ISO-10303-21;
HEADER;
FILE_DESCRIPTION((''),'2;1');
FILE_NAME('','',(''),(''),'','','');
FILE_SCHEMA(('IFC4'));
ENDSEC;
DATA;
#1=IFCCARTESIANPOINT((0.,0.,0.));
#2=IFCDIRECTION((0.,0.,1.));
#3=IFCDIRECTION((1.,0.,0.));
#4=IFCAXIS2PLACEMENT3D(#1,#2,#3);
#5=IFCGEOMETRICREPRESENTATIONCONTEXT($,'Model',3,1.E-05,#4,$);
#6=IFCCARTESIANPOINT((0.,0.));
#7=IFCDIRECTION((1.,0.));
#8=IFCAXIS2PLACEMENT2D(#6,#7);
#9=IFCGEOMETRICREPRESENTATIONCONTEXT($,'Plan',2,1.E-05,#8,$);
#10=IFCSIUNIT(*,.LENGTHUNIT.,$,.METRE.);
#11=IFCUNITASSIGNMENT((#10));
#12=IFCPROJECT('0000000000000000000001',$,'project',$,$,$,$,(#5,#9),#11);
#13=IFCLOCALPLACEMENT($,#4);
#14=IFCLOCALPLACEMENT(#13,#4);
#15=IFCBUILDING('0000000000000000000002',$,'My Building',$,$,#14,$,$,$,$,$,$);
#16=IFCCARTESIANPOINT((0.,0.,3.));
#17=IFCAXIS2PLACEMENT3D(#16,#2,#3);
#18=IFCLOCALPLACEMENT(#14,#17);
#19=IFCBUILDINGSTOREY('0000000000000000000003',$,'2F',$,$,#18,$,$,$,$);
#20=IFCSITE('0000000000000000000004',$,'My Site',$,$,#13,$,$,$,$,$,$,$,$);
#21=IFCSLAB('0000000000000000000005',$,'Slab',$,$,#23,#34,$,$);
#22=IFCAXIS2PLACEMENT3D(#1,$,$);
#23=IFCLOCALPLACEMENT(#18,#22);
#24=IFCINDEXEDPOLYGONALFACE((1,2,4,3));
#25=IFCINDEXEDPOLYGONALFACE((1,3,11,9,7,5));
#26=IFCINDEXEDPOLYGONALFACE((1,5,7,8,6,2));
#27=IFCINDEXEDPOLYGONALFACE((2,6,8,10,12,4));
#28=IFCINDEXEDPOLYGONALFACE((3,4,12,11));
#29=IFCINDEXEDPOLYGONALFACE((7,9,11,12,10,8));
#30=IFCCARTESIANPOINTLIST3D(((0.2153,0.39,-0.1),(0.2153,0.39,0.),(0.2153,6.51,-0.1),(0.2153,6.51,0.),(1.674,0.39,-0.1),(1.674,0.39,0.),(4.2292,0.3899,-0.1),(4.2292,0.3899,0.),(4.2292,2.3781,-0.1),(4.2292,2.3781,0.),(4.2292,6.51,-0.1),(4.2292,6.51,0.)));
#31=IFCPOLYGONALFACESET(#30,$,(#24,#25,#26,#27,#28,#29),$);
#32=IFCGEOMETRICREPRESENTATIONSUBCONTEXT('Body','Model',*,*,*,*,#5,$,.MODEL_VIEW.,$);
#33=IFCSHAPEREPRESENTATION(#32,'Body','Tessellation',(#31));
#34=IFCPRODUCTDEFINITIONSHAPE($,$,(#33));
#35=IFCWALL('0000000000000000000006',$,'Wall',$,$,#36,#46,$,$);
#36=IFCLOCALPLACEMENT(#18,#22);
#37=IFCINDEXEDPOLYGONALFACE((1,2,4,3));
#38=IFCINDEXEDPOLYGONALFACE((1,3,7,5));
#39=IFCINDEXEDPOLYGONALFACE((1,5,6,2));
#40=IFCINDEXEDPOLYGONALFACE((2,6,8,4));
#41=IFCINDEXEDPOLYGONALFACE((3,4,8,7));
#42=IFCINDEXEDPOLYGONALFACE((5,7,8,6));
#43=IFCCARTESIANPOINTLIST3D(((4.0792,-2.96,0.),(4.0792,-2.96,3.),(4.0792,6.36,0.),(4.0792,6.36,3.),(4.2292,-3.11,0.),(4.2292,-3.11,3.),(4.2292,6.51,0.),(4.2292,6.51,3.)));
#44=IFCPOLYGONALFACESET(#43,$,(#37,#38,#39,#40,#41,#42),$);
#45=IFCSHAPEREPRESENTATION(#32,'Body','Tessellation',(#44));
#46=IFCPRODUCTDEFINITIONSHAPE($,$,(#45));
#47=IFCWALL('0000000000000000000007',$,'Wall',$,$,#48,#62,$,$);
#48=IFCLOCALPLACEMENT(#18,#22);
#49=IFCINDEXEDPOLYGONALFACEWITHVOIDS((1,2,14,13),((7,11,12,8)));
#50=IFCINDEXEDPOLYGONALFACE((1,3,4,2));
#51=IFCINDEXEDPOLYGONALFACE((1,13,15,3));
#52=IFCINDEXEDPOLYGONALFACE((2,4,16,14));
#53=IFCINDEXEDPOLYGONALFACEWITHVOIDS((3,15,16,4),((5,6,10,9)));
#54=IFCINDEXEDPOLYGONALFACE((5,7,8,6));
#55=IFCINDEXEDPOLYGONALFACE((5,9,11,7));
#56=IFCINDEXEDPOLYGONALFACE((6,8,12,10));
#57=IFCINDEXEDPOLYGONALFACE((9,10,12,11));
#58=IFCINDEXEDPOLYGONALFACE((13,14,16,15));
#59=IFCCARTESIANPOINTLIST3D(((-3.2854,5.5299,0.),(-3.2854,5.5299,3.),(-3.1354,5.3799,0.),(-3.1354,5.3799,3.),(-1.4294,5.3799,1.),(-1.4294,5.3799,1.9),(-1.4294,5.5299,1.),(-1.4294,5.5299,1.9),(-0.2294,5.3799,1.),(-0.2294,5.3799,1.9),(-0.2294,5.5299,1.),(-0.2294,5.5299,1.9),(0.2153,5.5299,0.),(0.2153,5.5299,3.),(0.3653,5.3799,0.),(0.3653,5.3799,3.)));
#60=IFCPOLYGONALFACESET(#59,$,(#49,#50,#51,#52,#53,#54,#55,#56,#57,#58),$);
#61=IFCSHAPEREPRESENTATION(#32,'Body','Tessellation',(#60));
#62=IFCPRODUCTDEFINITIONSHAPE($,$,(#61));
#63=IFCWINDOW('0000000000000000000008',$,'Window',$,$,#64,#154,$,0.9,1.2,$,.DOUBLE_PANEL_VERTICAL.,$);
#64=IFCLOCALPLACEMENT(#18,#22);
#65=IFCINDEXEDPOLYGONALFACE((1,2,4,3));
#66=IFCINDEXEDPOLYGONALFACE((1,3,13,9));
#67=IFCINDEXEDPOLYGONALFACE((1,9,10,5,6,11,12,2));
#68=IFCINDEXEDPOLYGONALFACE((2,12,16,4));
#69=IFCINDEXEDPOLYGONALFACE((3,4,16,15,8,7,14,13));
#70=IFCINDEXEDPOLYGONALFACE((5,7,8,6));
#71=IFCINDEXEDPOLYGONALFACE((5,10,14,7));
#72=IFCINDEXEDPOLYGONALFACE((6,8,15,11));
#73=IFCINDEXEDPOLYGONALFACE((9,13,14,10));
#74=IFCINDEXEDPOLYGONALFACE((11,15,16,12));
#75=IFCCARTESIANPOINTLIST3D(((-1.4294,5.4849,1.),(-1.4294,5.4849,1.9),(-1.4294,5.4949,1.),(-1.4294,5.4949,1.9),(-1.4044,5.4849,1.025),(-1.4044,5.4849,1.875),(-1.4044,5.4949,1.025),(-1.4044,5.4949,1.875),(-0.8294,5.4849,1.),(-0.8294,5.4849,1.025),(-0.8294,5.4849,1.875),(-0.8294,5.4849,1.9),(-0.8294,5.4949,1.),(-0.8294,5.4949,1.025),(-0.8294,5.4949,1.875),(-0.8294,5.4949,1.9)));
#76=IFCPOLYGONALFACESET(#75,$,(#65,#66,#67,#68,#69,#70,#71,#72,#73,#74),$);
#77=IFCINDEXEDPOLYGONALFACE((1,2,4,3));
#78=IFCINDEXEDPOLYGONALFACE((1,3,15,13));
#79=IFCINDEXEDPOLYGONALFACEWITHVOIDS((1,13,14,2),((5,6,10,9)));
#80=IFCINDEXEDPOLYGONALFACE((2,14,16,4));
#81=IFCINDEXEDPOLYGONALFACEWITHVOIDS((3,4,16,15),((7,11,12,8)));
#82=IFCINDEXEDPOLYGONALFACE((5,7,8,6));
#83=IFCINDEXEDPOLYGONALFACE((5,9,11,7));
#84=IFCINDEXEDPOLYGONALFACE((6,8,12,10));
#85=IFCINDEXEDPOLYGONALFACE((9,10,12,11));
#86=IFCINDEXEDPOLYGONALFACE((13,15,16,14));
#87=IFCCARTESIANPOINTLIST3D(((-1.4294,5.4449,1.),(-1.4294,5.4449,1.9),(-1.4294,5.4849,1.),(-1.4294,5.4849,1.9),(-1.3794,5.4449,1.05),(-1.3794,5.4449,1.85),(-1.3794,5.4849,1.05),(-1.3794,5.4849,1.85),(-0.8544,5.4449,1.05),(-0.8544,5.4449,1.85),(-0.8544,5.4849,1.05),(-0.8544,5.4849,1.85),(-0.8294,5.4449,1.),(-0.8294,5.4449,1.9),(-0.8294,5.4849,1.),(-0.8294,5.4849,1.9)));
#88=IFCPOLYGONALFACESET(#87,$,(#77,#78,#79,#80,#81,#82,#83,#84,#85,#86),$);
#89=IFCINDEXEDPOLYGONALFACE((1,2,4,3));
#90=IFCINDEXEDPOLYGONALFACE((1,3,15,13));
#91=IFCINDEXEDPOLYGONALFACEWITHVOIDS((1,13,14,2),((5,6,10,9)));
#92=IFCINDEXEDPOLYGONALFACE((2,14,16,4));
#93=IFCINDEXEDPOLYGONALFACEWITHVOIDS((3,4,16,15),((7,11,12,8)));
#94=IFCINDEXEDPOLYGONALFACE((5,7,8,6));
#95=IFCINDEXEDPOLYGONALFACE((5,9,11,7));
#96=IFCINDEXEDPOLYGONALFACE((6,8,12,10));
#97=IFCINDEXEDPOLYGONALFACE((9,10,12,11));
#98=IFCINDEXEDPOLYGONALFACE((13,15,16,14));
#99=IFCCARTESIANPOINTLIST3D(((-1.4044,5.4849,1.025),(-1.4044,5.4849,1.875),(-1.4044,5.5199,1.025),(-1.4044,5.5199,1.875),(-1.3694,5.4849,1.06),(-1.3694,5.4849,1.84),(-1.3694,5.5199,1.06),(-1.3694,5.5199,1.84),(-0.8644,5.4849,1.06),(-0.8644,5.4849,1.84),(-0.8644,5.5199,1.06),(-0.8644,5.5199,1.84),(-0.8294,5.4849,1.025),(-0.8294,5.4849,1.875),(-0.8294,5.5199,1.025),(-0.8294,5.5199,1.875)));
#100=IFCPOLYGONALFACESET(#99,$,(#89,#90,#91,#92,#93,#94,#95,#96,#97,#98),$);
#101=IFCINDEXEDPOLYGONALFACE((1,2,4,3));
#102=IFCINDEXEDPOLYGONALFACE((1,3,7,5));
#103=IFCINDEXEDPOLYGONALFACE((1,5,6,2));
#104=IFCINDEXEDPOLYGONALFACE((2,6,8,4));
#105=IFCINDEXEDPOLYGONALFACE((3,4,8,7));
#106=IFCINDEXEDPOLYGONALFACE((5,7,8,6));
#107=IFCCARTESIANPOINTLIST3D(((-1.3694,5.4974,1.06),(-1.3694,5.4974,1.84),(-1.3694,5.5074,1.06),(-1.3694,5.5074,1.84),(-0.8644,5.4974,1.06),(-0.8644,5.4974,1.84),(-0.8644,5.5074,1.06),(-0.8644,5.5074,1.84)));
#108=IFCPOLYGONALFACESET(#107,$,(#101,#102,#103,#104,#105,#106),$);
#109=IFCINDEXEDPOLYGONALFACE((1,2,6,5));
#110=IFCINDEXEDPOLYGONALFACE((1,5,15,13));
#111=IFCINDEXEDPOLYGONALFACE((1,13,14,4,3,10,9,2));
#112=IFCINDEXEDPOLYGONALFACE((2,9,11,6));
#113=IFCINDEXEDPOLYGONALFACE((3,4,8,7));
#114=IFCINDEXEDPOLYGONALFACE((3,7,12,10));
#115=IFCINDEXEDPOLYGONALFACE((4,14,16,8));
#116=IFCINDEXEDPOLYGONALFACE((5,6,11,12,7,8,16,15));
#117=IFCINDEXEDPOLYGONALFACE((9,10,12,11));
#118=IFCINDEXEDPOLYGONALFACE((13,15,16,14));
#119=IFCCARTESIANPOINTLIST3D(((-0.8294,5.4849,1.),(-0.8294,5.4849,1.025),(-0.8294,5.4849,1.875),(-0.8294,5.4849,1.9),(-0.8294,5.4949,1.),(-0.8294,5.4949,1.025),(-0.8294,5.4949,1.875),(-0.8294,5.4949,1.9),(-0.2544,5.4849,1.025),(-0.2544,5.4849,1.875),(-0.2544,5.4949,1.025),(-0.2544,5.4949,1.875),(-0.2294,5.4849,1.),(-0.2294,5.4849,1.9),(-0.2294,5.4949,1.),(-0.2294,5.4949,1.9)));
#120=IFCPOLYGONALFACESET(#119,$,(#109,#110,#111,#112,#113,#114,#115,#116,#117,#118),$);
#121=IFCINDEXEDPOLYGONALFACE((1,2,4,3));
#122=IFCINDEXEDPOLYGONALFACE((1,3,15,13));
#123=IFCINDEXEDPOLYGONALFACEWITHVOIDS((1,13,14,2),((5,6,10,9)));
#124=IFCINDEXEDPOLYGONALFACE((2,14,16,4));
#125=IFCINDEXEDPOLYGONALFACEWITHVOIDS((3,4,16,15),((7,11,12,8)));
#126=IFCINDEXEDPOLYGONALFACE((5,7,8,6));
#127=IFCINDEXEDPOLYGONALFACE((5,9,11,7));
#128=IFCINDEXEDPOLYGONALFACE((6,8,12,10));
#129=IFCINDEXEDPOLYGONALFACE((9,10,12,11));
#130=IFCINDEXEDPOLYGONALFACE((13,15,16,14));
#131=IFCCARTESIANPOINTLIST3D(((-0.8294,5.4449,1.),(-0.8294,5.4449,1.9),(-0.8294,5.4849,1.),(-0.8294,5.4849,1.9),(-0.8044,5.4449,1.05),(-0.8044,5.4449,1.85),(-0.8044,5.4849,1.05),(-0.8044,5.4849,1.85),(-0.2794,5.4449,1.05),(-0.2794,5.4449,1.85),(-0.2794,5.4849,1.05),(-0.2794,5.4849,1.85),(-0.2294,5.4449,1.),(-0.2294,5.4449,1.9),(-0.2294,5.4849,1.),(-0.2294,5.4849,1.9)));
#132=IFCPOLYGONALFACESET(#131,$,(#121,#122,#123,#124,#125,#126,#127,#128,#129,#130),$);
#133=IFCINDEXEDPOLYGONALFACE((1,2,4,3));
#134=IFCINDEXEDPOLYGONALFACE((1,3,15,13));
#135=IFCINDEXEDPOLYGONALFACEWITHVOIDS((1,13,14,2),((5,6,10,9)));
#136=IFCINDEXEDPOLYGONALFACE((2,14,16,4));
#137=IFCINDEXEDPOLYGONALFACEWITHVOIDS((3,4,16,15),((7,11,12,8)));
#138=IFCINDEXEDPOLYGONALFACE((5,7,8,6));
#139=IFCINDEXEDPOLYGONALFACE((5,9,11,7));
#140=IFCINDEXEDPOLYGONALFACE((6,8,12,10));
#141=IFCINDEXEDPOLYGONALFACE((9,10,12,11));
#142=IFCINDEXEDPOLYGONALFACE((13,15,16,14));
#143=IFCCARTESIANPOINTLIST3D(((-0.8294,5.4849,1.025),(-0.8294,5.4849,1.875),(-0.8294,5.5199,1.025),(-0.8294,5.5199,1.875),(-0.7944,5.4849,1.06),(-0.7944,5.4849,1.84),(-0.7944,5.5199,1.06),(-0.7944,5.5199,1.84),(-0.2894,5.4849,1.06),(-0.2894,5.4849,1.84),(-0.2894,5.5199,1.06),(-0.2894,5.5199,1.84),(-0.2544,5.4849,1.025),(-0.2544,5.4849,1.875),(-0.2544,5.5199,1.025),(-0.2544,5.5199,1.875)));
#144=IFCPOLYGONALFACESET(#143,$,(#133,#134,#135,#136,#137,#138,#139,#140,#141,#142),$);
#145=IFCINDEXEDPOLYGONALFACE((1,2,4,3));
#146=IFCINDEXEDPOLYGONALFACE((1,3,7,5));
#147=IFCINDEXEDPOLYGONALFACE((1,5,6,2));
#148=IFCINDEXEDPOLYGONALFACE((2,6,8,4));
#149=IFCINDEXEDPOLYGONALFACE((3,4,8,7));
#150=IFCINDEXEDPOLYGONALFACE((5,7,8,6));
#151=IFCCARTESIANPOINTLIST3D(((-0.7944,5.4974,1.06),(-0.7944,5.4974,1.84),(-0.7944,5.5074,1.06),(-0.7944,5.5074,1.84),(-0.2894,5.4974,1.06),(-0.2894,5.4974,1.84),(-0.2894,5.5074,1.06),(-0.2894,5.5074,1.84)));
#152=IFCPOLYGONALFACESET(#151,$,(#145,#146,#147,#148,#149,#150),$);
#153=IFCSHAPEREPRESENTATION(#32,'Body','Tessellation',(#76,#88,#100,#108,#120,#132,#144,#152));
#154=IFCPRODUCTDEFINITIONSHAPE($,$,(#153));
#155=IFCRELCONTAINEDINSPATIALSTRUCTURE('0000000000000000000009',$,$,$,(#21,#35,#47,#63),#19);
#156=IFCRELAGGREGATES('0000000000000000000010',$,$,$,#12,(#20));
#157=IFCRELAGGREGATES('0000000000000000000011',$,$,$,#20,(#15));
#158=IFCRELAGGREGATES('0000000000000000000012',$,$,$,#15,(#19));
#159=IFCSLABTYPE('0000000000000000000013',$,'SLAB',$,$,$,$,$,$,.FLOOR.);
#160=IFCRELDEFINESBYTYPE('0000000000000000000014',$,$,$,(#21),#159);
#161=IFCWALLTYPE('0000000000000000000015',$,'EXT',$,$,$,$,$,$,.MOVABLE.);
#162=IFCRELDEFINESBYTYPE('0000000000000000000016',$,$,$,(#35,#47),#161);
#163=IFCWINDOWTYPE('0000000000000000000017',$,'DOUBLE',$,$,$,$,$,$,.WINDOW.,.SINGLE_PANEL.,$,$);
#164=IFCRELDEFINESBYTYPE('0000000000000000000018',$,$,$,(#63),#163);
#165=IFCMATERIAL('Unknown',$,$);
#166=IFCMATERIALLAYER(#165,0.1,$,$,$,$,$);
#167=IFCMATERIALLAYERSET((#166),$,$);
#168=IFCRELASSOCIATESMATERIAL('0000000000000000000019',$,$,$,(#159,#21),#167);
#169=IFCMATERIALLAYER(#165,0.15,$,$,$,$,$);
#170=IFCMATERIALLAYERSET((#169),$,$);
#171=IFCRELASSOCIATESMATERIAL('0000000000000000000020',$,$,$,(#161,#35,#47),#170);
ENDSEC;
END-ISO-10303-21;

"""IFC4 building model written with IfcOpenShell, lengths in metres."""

from ifc_helpers import new_model, entity, si_unit, frame, origin_with_axes, origin_2d_with_axis, place, context, subcontext, project, spatial, line, indexed_curve, outline, extrude, shape, source, transform, mapped, material, layer, layer_set, layer_usage, type_object, type_shapes, element, fill, save


model = new_model("IFC4")

# Units and contexts
model_context = context("Model", 3, precision=1e-05, world=origin_with_axes())
plan_context = context("Plan", 2, precision=1e-05, world=origin_2d_with_axis())
body_context_1 = subcontext(model_context, "Body", "Model", "MODEL_VIEW")
body_context_2 = subcontext(plan_context, "Body", "Plan", "PLAN_VIEW")
ifc_project = project(units=[si_unit("LENGTHUNIT", "METRE")], contexts=[model_context, plan_context])

# Site, building, storey
site_placement = place(None, origin_with_axes())
site = spatial("IfcSite", under=ifc_project, at=site_placement, Name="My Site")
building_placement = place(site_placement, origin_with_axes())
building = spatial("IfcBuilding", under=site, at=building_placement, Name="My Building")
storey_placement = place(building_placement, frame((0.0, 0.0, 3.0), z_axis=(0.0, 0.0, 1.0), x_axis=(1.0, 0.0, 0.0)))
storey = spatial("IfcBuildingStorey", under=building, at=storey_placement, Name="2F")

# Slab
ifc_material = material(Name="Unknown")
ifc_layer_1 = layer(ifc_material, 0.1)
ifc_layer_set_1 = layer_set([ifc_layer_1])
ifc_layer_usage_1 = layer_usage(ifc_layer_set_1, "AXIS3", "POSITIVE", -0.1)
slab_type = type_object("IfcSlabType", Name="SLAB", PredefinedType="FLOOR", material=ifc_layer_set_1)
slab_placement = place(storey_placement, frame((1.6739, 2.3781, 0.0), z_axis=(0.0, 0.0, 1.0), x_axis=(1.0, 0.0, 0.0)))
element("IfcSlab", 1, at=slab_placement, inside=storey, type_object=slab_type, material=ifc_layer_usage_1, Name="Slab", context=body_context_1, shape_type="SweptSolid", body=[
    extrude(outline(indexed_curve([(0.0, -1.9882), (-1.4586, -1.9882), (-1.4586, 4.1319), (2.5552, 4.1319), (2.5552, 0.0), (2.5553, -1.9883), (0.0, -1.9882)])), frame((0.0, 0.0, -0.1), z_axis=(0.0, 0.0, 1.0), x_axis=(1.0, 0.0, 0.0)), (0.0, 0.0, 1.0), 0.1),
])

# Wall
ifc_layer_2 = layer(ifc_material, 0.15)
ifc_layer_set_2 = layer_set([ifc_layer_2])
ifc_layer_usage_2 = layer_usage(ifc_layer_set_2, "AXIS2", "POSITIVE", -0.15)
wall_type_1 = type_object("IfcWallType", Name="EXT", PredefinedType="MOVABLE", material=ifc_layer_set_2)
wall_1_placement = place(storey_placement, frame((4.2292, 6.51, 0.0), z_axis=(0.0, 0.0, 1.0), x_axis=(0.0, -1.0, 0.0)))
element("IfcWall", 2, at=wall_1_placement, inside=storey, type_object=wall_type_1, material=ifc_layer_usage_2, Name="Wall", context=body_context_1, shape_type="SweptSolid", body=[
    extrude(outline(indexed_curve([(0.15, -0.15), (0.0, 0.0), (9.62, 0.0), (9.47, -0.15)], segments=[line(1, 2, 3, 4, 1)])), origin_with_axes(), (0.0, 0.0, 1.0), 3.0),
])

# Wall, opening, window
ifc_layer_usage_3 = layer_usage(ifc_layer_set_2, "AXIS2", "POSITIVE", -0.15)
wall_2_placement = place(storey_placement, frame((-3.2854, 5.5299, 0.0), z_axis=(0.0, 0.0, 1.0), x_axis=(1.0, 0.0, 0.0)))
wall_2 = element("IfcWall", 3, at=wall_2_placement, inside=storey, type_object=wall_type_1, material=ifc_layer_usage_3, Name="Wall", context=body_context_1, shape_type="SweptSolid", body=[
    extrude(outline(indexed_curve([(0.15, -0.15), (0.0, 0.0), (3.5007, 0.0), (3.6507, -0.15)], segments=[line(1, 2, 3, 4, 1)])), origin_with_axes(), (0.0, 0.0, 1.0), 3.0),
])
placement_1 = place(storey_placement, frame((-1.4294, 5.3949, 1.0), z_axis=(0.0, 0.0, 1.0), x_axis=(1.0, 0.0, 0.0)))
opening_1 = element("IfcOpeningElement", 4, at=placement_1, cuts=wall_2, PredefinedType="OPENING", context=body_context_1, shape_type="SweptSolid", body=[
    extrude(outline(indexed_curve([(0.0, 0.0), (1.2, 0.0), (1.2, 0.9), (0.0, 0.9)], segments=[line(1, 2, 3, 4, 1)])), frame((0.0, -0.6, 0.0), z_axis=(0.0, -1.0, 0.0), x_axis=(1.0, 0.0, 0.0)), (0.0, 0.0, -1.0), 1.2),
])
window_type_1 = type_object("IfcWindowType", Name="DOUBLE", PartitioningType="SINGLE_PANEL", PredefinedType="WINDOW")
shared_shape_1 = source(origin_with_axes(), body_context_1, "Body", "SweptSolid", [
    extrude(outline(indexed_curve([(0.6, 0.0), (0.0, 0.0), (0.0, 0.9), (0.6, 0.9), (0.6, 0.875), (0.025, 0.875), (0.025, 0.025), (0.6, 0.025)], segments=[line(1, 2, 3, 4, 5, 6, 7, 8, 1)])), frame((0.0, 0.09, 0.0), z_axis=(0.0, -1.0, 0.0), x_axis=(1.0, 0.0, 0.0)), (0.0, 0.0, -1.0), 0.01),
    extrude(outline(indexed_curve([(0.0, 0.0), (0.6, 0.0), (0.6, 0.9), (0.0, 0.9)], segments=[line(1, 2, 3, 4, 1)]), holes=[indexed_curve([(0.05, 0.05), (0.575, 0.05), (0.575, 0.85), (0.05, 0.85)], segments=[line(1, 2, 3, 4, 1)])]), frame((0.0, 0.05, 0.0), z_axis=(0.0, -1.0, 0.0), x_axis=(1.0, 0.0, 0.0)), (0.0, 0.0, -1.0), 0.04),
    extrude(outline(indexed_curve([(0.0, 0.0), (0.575, 0.0), (0.575, 0.85), (0.0, 0.85)], segments=[line(1, 2, 3, 4, 1)]), holes=[indexed_curve([(0.035, 0.035), (0.54, 0.035), (0.54, 0.815), (0.035, 0.815)], segments=[line(1, 2, 3, 4, 1)])]), frame((0.025, 0.09, 0.025), z_axis=(0.0, -1.0, 0.0), x_axis=(1.0, 0.0, 0.0)), (0.0, 0.0, -1.0), 0.035),
    extrude(outline(indexed_curve([(0.035, 0.035), (0.54, 0.035), (0.54, 0.815), (0.035, 0.815)], segments=[line(1, 2, 3, 4, 1)])), frame((0.025, 0.1025, 0.025), z_axis=(0.0, -1.0, 0.0), x_axis=(1.0, 0.0, 0.0)), (0.0, 0.0, -1.0), 0.01),
    extrude(outline(indexed_curve([(0.0, 0.9), (0.6, 0.9), (0.6, 0.0), (0.0, 0.0), (0.0, 0.025), (0.575, 0.025), (0.575, 0.875), (0.0, 0.875)], segments=[line(1, 2, 3, 4, 5, 6, 7, 8, 1)])), frame((0.6, 0.09, 0.0), z_axis=(0.0, -1.0, 0.0), x_axis=(1.0, 0.0, 0.0)), (0.0, 0.0, -1.0), 0.01),
    extrude(outline(indexed_curve([(0.0, 0.0), (0.6, 0.0), (0.6, 0.9), (0.0, 0.9)], segments=[line(1, 2, 3, 4, 1)]), holes=[indexed_curve([(0.025, 0.05), (0.55, 0.05), (0.55, 0.85), (0.025, 0.85)], segments=[line(1, 2, 3, 4, 1)])]), frame((0.6, 0.05, 0.0), z_axis=(0.0, -1.0, 0.0), x_axis=(1.0, 0.0, 0.0)), (0.0, 0.0, -1.0), 0.04),
    extrude(outline(indexed_curve([(0.0, 0.0), (0.575, 0.0), (0.575, 0.85), (0.0, 0.85)], segments=[line(1, 2, 3, 4, 1)]), holes=[indexed_curve([(0.035, 0.035), (0.54, 0.035), (0.54, 0.815), (0.035, 0.815)], segments=[line(1, 2, 3, 4, 1)])]), frame((0.6, 0.09, 0.025), z_axis=(0.0, -1.0, 0.0), x_axis=(1.0, 0.0, 0.0)), (0.0, 0.0, -1.0), 0.035),
    extrude(outline(indexed_curve([(0.035, 0.815), (0.54, 0.815), (0.54, 0.035), (0.035, 0.035), (0.035, 0.815)])), frame((0.6, 0.1025, 0.025), z_axis=(0.0, -1.0, 0.0), x_axis=(1.0, 0.0, 0.0)), (0.0, 0.0, -1.0), 0.01),
])
shared_shape_2 = source(origin_with_axes(), body_context_2, "Body", "Curve2D", [
    entity("IfcIndexedPolyCurve", entity("IfcCartesianPointList2D", [[0.05, 0.05], [0.575, 0.05]])),
    entity("IfcIndexedPolyCurve", entity("IfcCartesianPointList2D", [[0.0, 0.1], [0.025, 0.1], [0.025, 0.09], [0.05, 0.09], [0.05, 0.05], [0.0, 0.05]]), [entity("IfcLineIndex", [1, 2, 3, 4, 5, 6, 1])]),
    entity("IfcIndexedPolyCurve", entity("IfcCartesianPointList2D", [[0.6, 0.1], [0.6, 0.1], [0.6, 0.09], [0.575, 0.09], [0.575, 0.05], [0.6, 0.05]])),
    entity("IfcIndexedPolyCurve", entity("IfcCartesianPointList2D", [[0.025, 0.09], [0.06, 0.09], [0.06, 0.125], [0.025, 0.125]]), [entity("IfcLineIndex", [1, 2, 3, 4, 1])]),
    entity("IfcIndexedPolyCurve", entity("IfcCartesianPointList2D", [[0.6, 0.09], [0.565, 0.09], [0.565, 0.125], [0.6, 0.125]]), [entity("IfcLineIndex", [1, 2, 3, 4, 1])]),
    entity("IfcIndexedPolyCurve", entity("IfcCartesianPointList2D", [[0.06, 0.09], [0.565, 0.09]])),
    entity("IfcIndexedPolyCurve", entity("IfcCartesianPointList2D", [[0.06, 0.125], [0.565, 0.125]])),
    entity("IfcIndexedPolyCurve", entity("IfcCartesianPointList2D", [[0.06, 0.1075], [0.565, 0.1075]])),
    entity("IfcIndexedPolyCurve", entity("IfcCartesianPointList2D", [[0.625, 0.05], [1.15, 0.05]])),
    entity("IfcIndexedPolyCurve", entity("IfcCartesianPointList2D", [[0.6, 0.1], [0.6, 0.1], [0.6, 0.09], [0.625, 0.09], [0.625, 0.05], [0.6, 0.05]])),
    entity("IfcIndexedPolyCurve", entity("IfcCartesianPointList2D", [[1.2, 0.1], [1.175, 0.1], [1.175, 0.09], [1.15, 0.09], [1.15, 0.05], [1.2, 0.05]]), [entity("IfcLineIndex", [1, 2, 3, 4, 5, 6, 1])]),
    entity("IfcIndexedPolyCurve", entity("IfcCartesianPointList2D", [[0.6, 0.09], [0.635, 0.09], [0.635, 0.125], [0.6, 0.125]]), [entity("IfcLineIndex", [1, 2, 3, 4, 1])]),
    entity("IfcIndexedPolyCurve", entity("IfcCartesianPointList2D", [[1.175, 0.09], [1.14, 0.09], [1.14, 0.125], [1.175, 0.125]]), [entity("IfcLineIndex", [1, 2, 3, 4, 1])]),
    entity("IfcIndexedPolyCurve", entity("IfcCartesianPointList2D", [[0.635, 0.09], [1.14, 0.09]])),
    entity("IfcIndexedPolyCurve", entity("IfcCartesianPointList2D", [[0.635, 0.125], [1.14, 0.125]])),
    entity("IfcIndexedPolyCurve", entity("IfcCartesianPointList2D", [[0.635, 0.1075], [1.14, 0.1075]])),
])
type_shapes(window_type_1, [shared_shape_1, shared_shape_2])
window_1 = element("IfcWindow", 5, at=placement_1, inside=storey, type_object=window_type_1, Name="Window", OverallHeight=0.9, OverallWidth=1.2, PartitioningType="DOUBLE_PANEL_VERTICAL", shapes=[
    shape(body_context_1, "Body", "MappedRepresentation", [mapped(shared_shape_1, transform((0.0, 0.0, 0.0), x_axis=(1.0, 0.0, 0.0), y_axis=(0.0, 1.0, 0.0), z_axis=(0.0, 0.0, 1.0), scale=1.0))]),
    shape(body_context_2, "Body", "MappedRepresentation", [mapped(shared_shape_2, transform((0.0, 0.0, 0.0), x_axis=(1.0, 0.0, 0.0), y_axis=(0.0, 1.0, 0.0), z_axis=(0.0, 0.0, 1.0), scale=1.0))]),
])
fill(opening_1, window_1)

save(model, "model.ifc")
